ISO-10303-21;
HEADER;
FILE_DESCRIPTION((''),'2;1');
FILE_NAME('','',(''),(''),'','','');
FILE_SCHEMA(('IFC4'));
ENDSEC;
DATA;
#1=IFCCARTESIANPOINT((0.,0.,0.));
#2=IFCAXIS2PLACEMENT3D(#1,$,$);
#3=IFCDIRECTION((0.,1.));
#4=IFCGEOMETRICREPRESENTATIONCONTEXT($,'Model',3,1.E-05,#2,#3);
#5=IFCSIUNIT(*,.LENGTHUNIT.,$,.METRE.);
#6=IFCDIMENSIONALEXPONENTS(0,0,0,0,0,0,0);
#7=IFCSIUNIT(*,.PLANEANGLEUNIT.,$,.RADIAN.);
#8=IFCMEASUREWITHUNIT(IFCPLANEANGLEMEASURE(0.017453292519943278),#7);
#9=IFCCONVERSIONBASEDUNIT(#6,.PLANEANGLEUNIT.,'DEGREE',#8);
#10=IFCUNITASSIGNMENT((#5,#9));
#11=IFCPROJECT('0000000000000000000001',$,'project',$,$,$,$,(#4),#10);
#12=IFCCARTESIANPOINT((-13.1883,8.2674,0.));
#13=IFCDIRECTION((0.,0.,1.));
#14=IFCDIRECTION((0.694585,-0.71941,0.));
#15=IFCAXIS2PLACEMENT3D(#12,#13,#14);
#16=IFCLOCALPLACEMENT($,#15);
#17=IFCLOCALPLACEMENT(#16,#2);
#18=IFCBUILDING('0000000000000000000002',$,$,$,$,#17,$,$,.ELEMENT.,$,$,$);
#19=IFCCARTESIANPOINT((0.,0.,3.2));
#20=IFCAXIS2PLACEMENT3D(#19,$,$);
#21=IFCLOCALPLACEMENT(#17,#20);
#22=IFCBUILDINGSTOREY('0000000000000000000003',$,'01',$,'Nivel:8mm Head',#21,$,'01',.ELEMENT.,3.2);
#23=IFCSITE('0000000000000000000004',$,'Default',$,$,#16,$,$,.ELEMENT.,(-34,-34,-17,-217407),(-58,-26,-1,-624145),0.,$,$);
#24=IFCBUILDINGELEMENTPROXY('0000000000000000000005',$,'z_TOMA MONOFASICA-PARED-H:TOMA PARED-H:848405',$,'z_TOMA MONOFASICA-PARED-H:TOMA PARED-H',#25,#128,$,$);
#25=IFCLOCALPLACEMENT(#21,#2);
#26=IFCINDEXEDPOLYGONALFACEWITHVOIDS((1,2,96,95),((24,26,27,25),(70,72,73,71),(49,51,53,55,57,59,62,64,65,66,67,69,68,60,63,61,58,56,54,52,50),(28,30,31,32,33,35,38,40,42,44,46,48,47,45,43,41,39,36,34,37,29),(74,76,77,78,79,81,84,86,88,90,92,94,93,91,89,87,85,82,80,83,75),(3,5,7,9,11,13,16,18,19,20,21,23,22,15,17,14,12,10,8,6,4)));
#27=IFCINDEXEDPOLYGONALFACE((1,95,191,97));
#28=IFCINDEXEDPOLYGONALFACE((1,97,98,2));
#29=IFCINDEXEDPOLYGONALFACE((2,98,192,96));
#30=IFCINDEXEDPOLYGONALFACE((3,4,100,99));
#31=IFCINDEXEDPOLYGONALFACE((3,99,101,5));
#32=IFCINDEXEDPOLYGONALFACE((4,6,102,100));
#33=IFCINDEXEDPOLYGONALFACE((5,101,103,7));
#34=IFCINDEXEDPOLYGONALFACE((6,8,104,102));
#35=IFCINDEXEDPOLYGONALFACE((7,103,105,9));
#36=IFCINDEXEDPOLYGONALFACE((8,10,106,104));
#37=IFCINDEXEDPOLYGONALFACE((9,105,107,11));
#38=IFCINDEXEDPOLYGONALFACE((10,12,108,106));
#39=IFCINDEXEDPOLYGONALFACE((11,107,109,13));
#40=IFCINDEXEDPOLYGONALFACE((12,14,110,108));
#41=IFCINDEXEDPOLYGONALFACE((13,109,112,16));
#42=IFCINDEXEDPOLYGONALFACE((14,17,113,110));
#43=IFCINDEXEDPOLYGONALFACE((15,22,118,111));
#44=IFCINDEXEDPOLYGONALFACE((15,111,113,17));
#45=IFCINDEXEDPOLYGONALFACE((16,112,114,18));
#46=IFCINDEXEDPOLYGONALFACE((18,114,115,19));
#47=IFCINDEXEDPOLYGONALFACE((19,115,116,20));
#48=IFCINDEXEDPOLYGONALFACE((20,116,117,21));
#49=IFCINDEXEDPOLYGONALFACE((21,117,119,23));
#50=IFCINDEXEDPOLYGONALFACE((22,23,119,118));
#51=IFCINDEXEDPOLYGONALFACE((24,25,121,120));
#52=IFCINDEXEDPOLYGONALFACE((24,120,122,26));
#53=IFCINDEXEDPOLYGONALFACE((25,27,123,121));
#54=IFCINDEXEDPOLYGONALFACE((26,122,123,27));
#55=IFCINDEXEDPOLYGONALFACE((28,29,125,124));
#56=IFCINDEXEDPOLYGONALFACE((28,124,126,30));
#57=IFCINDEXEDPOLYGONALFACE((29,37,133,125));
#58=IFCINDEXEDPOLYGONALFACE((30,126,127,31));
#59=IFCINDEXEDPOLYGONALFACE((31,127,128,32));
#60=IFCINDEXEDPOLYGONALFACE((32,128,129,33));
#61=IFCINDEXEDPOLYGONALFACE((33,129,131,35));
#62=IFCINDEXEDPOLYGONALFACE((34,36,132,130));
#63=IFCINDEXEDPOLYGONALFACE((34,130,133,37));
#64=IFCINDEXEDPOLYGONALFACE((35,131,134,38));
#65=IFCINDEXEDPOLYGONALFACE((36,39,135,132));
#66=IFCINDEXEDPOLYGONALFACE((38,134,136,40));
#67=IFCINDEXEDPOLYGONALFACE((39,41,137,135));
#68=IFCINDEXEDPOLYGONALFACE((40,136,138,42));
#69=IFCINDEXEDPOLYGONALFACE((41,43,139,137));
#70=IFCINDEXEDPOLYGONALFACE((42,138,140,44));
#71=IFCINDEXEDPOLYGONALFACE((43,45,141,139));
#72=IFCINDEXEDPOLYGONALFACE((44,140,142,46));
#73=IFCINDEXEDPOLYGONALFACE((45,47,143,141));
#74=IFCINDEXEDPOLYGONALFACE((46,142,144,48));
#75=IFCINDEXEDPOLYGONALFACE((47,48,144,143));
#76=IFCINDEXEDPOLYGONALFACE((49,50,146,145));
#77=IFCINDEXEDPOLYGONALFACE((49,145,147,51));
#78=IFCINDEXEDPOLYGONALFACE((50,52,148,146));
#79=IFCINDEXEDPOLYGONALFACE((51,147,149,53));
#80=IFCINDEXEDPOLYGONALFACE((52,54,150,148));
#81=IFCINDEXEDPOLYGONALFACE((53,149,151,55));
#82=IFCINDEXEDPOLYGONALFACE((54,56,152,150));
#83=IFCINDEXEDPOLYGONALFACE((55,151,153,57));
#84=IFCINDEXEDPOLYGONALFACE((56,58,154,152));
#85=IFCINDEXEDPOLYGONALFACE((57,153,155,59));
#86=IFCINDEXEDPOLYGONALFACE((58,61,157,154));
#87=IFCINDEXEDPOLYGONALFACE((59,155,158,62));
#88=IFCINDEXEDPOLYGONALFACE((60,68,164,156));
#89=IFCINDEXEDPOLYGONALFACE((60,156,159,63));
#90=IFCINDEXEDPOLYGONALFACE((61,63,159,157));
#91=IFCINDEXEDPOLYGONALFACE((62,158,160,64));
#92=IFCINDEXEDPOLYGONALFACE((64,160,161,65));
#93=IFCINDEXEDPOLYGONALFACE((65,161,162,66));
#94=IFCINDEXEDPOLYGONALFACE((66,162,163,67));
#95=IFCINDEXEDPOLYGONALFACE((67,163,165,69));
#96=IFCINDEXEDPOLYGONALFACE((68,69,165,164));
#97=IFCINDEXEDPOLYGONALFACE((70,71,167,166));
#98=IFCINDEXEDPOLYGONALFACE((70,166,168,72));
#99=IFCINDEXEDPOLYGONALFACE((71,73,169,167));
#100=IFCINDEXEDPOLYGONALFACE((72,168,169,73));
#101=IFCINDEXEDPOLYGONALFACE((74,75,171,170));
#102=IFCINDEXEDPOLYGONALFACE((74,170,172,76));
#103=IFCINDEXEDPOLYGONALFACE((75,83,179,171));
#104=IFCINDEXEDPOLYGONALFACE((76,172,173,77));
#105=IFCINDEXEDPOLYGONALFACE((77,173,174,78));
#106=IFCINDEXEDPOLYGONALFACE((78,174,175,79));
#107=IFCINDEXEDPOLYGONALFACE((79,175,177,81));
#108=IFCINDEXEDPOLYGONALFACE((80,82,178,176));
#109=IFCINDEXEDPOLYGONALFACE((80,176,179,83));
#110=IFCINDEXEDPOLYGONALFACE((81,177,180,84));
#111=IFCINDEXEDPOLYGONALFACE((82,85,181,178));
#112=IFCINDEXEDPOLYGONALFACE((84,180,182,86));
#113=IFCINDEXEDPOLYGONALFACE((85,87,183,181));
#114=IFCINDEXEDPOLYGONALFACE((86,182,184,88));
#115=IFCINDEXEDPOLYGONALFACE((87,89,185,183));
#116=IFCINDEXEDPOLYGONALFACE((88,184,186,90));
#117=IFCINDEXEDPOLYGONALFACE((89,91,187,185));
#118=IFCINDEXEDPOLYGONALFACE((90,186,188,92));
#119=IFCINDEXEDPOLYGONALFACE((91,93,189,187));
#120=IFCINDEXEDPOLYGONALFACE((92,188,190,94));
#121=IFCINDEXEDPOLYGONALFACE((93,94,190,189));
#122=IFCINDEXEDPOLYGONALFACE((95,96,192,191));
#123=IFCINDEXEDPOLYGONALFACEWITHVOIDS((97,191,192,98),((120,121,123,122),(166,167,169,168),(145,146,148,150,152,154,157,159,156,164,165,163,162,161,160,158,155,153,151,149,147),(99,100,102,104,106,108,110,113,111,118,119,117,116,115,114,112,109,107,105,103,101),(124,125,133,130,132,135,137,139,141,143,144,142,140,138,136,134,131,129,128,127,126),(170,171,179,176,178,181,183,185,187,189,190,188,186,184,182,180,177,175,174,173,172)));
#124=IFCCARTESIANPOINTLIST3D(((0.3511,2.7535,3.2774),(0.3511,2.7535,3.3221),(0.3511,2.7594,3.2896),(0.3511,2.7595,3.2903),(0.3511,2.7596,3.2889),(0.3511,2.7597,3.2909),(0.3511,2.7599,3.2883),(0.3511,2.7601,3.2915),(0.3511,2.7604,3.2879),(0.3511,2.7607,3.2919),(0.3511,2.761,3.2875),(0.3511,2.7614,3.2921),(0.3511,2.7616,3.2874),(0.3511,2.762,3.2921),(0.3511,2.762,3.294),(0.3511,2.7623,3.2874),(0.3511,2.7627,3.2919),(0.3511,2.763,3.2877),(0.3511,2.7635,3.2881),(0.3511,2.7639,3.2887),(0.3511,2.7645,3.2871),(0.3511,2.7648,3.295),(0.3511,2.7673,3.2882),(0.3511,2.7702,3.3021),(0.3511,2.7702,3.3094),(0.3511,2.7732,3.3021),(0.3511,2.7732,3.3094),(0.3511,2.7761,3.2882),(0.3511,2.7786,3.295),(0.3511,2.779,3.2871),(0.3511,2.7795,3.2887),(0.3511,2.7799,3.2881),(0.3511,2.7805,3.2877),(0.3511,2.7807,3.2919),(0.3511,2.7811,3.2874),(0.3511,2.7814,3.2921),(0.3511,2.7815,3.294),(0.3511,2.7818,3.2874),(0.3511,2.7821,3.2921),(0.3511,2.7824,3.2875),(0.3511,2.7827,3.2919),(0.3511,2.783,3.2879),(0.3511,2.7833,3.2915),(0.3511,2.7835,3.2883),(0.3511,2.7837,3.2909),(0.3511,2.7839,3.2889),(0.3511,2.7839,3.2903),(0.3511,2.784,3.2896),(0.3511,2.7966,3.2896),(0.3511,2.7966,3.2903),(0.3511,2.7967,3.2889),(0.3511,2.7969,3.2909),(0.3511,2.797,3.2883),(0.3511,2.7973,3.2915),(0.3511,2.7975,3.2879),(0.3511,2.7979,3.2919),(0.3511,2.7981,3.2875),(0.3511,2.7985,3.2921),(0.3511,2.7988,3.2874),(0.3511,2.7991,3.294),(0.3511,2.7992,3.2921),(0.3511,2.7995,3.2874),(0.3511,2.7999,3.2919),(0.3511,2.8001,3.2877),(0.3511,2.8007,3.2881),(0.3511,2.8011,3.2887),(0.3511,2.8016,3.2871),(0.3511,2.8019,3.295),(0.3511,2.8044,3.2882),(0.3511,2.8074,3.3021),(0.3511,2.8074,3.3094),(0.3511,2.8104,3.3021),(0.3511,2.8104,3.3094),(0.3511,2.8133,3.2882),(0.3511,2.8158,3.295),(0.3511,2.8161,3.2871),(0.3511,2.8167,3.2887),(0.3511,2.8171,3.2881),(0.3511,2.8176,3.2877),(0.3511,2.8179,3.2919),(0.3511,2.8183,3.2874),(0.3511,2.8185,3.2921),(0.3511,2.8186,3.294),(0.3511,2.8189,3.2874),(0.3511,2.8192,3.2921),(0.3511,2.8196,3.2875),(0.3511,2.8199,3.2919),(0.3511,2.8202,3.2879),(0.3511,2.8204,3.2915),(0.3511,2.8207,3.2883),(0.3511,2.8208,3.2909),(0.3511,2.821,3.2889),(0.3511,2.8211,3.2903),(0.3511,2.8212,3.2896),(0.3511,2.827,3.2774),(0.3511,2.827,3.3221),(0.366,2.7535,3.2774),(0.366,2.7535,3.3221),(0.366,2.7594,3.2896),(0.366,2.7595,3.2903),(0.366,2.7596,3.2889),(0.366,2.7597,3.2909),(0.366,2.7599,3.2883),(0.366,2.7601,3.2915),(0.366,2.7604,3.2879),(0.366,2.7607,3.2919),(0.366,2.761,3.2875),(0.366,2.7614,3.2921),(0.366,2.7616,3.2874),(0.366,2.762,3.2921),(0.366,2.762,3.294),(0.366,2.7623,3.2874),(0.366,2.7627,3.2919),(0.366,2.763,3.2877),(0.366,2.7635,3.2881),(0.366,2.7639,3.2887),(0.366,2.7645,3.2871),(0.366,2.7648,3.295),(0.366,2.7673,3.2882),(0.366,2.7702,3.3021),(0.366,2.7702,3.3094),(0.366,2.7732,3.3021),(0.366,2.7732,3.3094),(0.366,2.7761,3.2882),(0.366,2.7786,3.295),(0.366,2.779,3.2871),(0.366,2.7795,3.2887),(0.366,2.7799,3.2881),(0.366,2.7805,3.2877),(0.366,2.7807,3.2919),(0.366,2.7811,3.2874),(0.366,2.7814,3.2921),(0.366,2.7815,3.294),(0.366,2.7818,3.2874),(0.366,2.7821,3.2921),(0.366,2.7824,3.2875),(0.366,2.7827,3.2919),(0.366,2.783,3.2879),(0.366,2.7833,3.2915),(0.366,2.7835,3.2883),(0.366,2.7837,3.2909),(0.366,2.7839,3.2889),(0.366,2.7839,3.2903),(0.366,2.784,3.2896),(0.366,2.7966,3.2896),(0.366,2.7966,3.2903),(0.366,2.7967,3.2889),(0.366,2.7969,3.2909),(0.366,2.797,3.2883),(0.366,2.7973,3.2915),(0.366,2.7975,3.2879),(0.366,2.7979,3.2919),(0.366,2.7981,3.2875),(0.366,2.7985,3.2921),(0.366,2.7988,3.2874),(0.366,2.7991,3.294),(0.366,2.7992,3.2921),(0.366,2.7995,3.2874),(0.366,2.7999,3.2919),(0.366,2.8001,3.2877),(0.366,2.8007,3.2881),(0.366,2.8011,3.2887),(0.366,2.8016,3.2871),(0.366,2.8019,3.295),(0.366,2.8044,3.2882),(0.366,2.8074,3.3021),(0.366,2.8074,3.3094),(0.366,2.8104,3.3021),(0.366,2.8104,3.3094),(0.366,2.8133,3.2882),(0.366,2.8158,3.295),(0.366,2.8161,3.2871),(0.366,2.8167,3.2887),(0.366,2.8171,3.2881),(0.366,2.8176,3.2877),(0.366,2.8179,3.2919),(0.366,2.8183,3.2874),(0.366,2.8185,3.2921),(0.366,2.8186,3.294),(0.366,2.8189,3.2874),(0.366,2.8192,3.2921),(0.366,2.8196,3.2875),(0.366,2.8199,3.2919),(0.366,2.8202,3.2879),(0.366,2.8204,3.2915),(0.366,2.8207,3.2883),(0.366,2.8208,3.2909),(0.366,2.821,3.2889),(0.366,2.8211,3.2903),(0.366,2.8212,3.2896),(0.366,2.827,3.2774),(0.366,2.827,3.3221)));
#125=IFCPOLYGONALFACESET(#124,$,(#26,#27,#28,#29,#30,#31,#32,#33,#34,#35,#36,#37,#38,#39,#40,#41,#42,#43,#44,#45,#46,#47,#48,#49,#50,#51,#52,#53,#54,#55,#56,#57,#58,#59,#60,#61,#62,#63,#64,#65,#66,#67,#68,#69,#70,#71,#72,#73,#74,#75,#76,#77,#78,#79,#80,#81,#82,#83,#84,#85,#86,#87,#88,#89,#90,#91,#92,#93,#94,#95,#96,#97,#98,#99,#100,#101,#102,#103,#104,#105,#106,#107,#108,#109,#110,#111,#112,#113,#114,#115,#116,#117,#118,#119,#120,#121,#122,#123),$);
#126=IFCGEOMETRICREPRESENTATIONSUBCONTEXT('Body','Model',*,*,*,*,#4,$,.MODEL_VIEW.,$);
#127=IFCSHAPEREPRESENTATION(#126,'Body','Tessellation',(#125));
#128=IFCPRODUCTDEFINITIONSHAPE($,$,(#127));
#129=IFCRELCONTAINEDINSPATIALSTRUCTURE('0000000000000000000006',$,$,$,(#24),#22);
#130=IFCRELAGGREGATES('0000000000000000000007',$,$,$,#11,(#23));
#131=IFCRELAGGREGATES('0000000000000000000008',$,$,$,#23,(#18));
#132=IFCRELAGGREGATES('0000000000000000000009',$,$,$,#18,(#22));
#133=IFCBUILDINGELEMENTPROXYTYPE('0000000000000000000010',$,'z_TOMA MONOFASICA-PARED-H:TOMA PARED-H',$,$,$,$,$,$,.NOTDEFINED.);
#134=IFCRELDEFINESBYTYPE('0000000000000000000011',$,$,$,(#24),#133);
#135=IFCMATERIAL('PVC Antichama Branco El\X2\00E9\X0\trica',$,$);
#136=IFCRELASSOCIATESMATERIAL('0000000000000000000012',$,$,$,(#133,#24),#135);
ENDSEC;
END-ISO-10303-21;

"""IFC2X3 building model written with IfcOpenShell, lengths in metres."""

from ifc_helpers import new_model, entity, si_unit, converted_unit, direction, frame, frame_2d, origin, place, context, subcontext, project, spatial, polyline, circle_curve, parameter, trimmed, segment, composite_curve, outline, extrude, source, transform, mapped, material, type_object, type_shapes, element, save


model = new_model("IFC2X3")

# Units and contexts
model_context = context("Model", 3, precision=1e-05, world=origin(), true_north=direction((0.0, 1.0)))
body_context = subcontext(model_context, "Body", "Model", "MODEL_VIEW")
ifc_project = project(units=[si_unit("LENGTHUNIT", "METRE"), converted_unit("PLANEANGLEUNIT", "DEGREE", entity("IfcPlaneAngleMeasure", 0.017453292519943278), si_unit("PLANEANGLEUNIT", "RADIAN"), dimensions=[0, 0, 0, 0, 0, 0, 0])], contexts=[model_context])

# Site, building, storey
site_placement = place(None, frame((-13.1883, 8.2674, 0.0), z_axis=(0.0, 0.0, 1.0), x_axis=(0.694585, -0.71941, 0.0)))
site = spatial("IfcSite", under=ifc_project, at=site_placement, Name="Default", CompositionType="ELEMENT", RefLatitude=(-34, -34, -17, -217407), RefLongitude=(-58, -26, -1, -624145), RefElevation=0.0)
building_placement = place(site_placement, origin())
building = spatial("IfcBuilding", under=site, at=building_placement, CompositionType="ELEMENT")
storey_placement = place(building_placement, frame((0.0, 0.0, 3.2)))
storey = spatial("IfcBuildingStorey", under=building, at=storey_placement, Name="01", ObjectType="Nivel:8mm Head", LongName="01", CompositionType="ELEMENT", Elevation=3.2)

# Building element proxy
ifc_material_1 = material(Name="PVC Antichama Branco Elétrica")
building_element_proxy_type_1 = type_object("IfcBuildingElementProxyType", Name="z_TOMA MONOFASICA-PARED-H:TOMA PARED-H", PredefinedType="NOTDEFINED", material=ifc_material_1)
shared_shape_1 = source(origin(), body_context, "Body", "SweptSolid", [
    extrude(outline(polyline([(-0.0368, -0.0223), (0.0368, -0.0223), (0.0368, 0.0223), (-0.0368, 0.0223), (-0.0368, -0.0223)]), holes=[composite_curve([segment(polyline([(0.0141, 0.0115), (0.0116, 0.0047)]), True, "CONTINUOUS"), segment(polyline([(0.0116, 0.0047), (0.0088, 0.0057)]), True, "CONTINUOUS"), segment(polyline([(0.0088, 0.0057), (0.0096, 0.0078)]), True, "CONTINUOUS"), segment(trimmed(circle_curve(frame_2d((0.0087, 0.0099), x_axis=(1.0, 0.0)), 0.0024), [parameter(27.118901)], [parameter(292.881099)], True, "PARAMETER"), False, "CONTINUOUS"), segment(polyline([(0.0108, 0.011), (0.0113, 0.0126)]), True, "CONTINUOUS"), segment(polyline([(0.0113, 0.0126), (0.0141, 0.0115)]), True, "CONTINUOUS")], self_intersect=False), composite_curve([segment(polyline([(0.0255, 0.0047), (0.023, 0.0115)]), True, "CONTINUOUS"), segment(polyline([(0.023, 0.0115), (0.0258, 0.0126)]), True, "CONTINUOUS"), segment(polyline([(0.0258, 0.0126), (0.0264, 0.011)]), True, "CONTINUOUS"), segment(trimmed(circle_curve(frame_2d((0.0285, 0.0099), x_axis=(1.0, 0.0)), 0.0024), [parameter(247.118901)], [parameter(152.881099)], True, "PARAMETER"), False, "CONTINUOUS"), segment(polyline([(0.0276, 0.0078), (0.0283, 0.0057)]), True, "CONTINUOUS"), segment(polyline([(0.0283, 0.0057), (0.0255, 0.0047)]), True, "CONTINUOUS")], self_intersect=False), polyline([(0.0201, -0.0024), (0.0201, -0.0097), (0.0171, -0.0097), (0.0171, -0.0024), (0.0201, -0.0024)]), composite_curve([segment(polyline([(-0.0141, 0.0115), (-0.0113, 0.0126)]), True, "CONTINUOUS"), segment(polyline([(-0.0113, 0.0126), (-0.0108, 0.011)]), True, "CONTINUOUS"), segment(trimmed(circle_curve(frame_2d((-0.0087, 0.0099), x_axis=(1.0, 0.0)), 0.0024), [parameter(247.118901)], [parameter(152.881099)], True, "PARAMETER"), False, "CONTINUOUS"), segment(polyline([(-0.0096, 0.0078), (-0.0088, 0.0057)]), True, "CONTINUOUS"), segment(polyline([(-0.0088, 0.0057), (-0.0116, 0.0047)]), True, "CONTINUOUS"), segment(polyline([(-0.0116, 0.0047), (-0.0141, 0.0115)]), True, "CONTINUOUS")], self_intersect=False), composite_curve([segment(polyline([(-0.0255, 0.0047), (-0.0283, 0.0057)]), True, "CONTINUOUS"), segment(polyline([(-0.0283, 0.0057), (-0.0276, 0.0078)]), True, "CONTINUOUS"), segment(trimmed(circle_curve(frame_2d((-0.0285, 0.0099), x_axis=(1.0, 0.0)), 0.0024), [parameter(27.118901)], [parameter(292.881099)], True, "PARAMETER"), False, "CONTINUOUS"), segment(polyline([(-0.0264, 0.011), (-0.0258, 0.0126)]), True, "CONTINUOUS"), segment(polyline([(-0.0258, 0.0126), (-0.023, 0.0115)]), True, "CONTINUOUS"), segment(polyline([(-0.023, 0.0115), (-0.0255, 0.0047)]), True, "CONTINUOUS")], self_intersect=False), polyline([(-0.0201, -0.0024), (-0.0171, -0.0024), (-0.0171, -0.0097), (-0.0201, -0.0097), (-0.0201, -0.0024)])]), frame((0.0, -0.005, 0.0223), z_axis=(0.0, 1.0, 0.0), x_axis=(1.0, 0.0, 0.0)), (0.0, 0.0, 1.0), 0.0148),
])
type_shapes(building_element_proxy_type_1, [shared_shape_1])
for number, where, z_axis, x_axis, name in (
    (1, (0.361, 2.7903, 3.2774), (0.0, 0.0, 1.0), (0.0, 1.0, 0.0), "z_TOMA MONOFASICA-PARED-H:TOMA PARED-H:848405"),
):
    element("IfcBuildingElementProxy", number, at=place(storey_placement, frame(where, z_axis=z_axis, x_axis=x_axis)), inside=storey, type_object=building_element_proxy_type_1, material=ifc_material_1, Name=name, ObjectType="z_TOMA MONOFASICA-PARED-H:TOMA PARED-H", context=body_context, shape_type="MappedRepresentation", body=[
        mapped(shared_shape_1, transform((0.0, 0.0, 0.0), scale=1.0)),
    ])

save(model, "model.ifc")
